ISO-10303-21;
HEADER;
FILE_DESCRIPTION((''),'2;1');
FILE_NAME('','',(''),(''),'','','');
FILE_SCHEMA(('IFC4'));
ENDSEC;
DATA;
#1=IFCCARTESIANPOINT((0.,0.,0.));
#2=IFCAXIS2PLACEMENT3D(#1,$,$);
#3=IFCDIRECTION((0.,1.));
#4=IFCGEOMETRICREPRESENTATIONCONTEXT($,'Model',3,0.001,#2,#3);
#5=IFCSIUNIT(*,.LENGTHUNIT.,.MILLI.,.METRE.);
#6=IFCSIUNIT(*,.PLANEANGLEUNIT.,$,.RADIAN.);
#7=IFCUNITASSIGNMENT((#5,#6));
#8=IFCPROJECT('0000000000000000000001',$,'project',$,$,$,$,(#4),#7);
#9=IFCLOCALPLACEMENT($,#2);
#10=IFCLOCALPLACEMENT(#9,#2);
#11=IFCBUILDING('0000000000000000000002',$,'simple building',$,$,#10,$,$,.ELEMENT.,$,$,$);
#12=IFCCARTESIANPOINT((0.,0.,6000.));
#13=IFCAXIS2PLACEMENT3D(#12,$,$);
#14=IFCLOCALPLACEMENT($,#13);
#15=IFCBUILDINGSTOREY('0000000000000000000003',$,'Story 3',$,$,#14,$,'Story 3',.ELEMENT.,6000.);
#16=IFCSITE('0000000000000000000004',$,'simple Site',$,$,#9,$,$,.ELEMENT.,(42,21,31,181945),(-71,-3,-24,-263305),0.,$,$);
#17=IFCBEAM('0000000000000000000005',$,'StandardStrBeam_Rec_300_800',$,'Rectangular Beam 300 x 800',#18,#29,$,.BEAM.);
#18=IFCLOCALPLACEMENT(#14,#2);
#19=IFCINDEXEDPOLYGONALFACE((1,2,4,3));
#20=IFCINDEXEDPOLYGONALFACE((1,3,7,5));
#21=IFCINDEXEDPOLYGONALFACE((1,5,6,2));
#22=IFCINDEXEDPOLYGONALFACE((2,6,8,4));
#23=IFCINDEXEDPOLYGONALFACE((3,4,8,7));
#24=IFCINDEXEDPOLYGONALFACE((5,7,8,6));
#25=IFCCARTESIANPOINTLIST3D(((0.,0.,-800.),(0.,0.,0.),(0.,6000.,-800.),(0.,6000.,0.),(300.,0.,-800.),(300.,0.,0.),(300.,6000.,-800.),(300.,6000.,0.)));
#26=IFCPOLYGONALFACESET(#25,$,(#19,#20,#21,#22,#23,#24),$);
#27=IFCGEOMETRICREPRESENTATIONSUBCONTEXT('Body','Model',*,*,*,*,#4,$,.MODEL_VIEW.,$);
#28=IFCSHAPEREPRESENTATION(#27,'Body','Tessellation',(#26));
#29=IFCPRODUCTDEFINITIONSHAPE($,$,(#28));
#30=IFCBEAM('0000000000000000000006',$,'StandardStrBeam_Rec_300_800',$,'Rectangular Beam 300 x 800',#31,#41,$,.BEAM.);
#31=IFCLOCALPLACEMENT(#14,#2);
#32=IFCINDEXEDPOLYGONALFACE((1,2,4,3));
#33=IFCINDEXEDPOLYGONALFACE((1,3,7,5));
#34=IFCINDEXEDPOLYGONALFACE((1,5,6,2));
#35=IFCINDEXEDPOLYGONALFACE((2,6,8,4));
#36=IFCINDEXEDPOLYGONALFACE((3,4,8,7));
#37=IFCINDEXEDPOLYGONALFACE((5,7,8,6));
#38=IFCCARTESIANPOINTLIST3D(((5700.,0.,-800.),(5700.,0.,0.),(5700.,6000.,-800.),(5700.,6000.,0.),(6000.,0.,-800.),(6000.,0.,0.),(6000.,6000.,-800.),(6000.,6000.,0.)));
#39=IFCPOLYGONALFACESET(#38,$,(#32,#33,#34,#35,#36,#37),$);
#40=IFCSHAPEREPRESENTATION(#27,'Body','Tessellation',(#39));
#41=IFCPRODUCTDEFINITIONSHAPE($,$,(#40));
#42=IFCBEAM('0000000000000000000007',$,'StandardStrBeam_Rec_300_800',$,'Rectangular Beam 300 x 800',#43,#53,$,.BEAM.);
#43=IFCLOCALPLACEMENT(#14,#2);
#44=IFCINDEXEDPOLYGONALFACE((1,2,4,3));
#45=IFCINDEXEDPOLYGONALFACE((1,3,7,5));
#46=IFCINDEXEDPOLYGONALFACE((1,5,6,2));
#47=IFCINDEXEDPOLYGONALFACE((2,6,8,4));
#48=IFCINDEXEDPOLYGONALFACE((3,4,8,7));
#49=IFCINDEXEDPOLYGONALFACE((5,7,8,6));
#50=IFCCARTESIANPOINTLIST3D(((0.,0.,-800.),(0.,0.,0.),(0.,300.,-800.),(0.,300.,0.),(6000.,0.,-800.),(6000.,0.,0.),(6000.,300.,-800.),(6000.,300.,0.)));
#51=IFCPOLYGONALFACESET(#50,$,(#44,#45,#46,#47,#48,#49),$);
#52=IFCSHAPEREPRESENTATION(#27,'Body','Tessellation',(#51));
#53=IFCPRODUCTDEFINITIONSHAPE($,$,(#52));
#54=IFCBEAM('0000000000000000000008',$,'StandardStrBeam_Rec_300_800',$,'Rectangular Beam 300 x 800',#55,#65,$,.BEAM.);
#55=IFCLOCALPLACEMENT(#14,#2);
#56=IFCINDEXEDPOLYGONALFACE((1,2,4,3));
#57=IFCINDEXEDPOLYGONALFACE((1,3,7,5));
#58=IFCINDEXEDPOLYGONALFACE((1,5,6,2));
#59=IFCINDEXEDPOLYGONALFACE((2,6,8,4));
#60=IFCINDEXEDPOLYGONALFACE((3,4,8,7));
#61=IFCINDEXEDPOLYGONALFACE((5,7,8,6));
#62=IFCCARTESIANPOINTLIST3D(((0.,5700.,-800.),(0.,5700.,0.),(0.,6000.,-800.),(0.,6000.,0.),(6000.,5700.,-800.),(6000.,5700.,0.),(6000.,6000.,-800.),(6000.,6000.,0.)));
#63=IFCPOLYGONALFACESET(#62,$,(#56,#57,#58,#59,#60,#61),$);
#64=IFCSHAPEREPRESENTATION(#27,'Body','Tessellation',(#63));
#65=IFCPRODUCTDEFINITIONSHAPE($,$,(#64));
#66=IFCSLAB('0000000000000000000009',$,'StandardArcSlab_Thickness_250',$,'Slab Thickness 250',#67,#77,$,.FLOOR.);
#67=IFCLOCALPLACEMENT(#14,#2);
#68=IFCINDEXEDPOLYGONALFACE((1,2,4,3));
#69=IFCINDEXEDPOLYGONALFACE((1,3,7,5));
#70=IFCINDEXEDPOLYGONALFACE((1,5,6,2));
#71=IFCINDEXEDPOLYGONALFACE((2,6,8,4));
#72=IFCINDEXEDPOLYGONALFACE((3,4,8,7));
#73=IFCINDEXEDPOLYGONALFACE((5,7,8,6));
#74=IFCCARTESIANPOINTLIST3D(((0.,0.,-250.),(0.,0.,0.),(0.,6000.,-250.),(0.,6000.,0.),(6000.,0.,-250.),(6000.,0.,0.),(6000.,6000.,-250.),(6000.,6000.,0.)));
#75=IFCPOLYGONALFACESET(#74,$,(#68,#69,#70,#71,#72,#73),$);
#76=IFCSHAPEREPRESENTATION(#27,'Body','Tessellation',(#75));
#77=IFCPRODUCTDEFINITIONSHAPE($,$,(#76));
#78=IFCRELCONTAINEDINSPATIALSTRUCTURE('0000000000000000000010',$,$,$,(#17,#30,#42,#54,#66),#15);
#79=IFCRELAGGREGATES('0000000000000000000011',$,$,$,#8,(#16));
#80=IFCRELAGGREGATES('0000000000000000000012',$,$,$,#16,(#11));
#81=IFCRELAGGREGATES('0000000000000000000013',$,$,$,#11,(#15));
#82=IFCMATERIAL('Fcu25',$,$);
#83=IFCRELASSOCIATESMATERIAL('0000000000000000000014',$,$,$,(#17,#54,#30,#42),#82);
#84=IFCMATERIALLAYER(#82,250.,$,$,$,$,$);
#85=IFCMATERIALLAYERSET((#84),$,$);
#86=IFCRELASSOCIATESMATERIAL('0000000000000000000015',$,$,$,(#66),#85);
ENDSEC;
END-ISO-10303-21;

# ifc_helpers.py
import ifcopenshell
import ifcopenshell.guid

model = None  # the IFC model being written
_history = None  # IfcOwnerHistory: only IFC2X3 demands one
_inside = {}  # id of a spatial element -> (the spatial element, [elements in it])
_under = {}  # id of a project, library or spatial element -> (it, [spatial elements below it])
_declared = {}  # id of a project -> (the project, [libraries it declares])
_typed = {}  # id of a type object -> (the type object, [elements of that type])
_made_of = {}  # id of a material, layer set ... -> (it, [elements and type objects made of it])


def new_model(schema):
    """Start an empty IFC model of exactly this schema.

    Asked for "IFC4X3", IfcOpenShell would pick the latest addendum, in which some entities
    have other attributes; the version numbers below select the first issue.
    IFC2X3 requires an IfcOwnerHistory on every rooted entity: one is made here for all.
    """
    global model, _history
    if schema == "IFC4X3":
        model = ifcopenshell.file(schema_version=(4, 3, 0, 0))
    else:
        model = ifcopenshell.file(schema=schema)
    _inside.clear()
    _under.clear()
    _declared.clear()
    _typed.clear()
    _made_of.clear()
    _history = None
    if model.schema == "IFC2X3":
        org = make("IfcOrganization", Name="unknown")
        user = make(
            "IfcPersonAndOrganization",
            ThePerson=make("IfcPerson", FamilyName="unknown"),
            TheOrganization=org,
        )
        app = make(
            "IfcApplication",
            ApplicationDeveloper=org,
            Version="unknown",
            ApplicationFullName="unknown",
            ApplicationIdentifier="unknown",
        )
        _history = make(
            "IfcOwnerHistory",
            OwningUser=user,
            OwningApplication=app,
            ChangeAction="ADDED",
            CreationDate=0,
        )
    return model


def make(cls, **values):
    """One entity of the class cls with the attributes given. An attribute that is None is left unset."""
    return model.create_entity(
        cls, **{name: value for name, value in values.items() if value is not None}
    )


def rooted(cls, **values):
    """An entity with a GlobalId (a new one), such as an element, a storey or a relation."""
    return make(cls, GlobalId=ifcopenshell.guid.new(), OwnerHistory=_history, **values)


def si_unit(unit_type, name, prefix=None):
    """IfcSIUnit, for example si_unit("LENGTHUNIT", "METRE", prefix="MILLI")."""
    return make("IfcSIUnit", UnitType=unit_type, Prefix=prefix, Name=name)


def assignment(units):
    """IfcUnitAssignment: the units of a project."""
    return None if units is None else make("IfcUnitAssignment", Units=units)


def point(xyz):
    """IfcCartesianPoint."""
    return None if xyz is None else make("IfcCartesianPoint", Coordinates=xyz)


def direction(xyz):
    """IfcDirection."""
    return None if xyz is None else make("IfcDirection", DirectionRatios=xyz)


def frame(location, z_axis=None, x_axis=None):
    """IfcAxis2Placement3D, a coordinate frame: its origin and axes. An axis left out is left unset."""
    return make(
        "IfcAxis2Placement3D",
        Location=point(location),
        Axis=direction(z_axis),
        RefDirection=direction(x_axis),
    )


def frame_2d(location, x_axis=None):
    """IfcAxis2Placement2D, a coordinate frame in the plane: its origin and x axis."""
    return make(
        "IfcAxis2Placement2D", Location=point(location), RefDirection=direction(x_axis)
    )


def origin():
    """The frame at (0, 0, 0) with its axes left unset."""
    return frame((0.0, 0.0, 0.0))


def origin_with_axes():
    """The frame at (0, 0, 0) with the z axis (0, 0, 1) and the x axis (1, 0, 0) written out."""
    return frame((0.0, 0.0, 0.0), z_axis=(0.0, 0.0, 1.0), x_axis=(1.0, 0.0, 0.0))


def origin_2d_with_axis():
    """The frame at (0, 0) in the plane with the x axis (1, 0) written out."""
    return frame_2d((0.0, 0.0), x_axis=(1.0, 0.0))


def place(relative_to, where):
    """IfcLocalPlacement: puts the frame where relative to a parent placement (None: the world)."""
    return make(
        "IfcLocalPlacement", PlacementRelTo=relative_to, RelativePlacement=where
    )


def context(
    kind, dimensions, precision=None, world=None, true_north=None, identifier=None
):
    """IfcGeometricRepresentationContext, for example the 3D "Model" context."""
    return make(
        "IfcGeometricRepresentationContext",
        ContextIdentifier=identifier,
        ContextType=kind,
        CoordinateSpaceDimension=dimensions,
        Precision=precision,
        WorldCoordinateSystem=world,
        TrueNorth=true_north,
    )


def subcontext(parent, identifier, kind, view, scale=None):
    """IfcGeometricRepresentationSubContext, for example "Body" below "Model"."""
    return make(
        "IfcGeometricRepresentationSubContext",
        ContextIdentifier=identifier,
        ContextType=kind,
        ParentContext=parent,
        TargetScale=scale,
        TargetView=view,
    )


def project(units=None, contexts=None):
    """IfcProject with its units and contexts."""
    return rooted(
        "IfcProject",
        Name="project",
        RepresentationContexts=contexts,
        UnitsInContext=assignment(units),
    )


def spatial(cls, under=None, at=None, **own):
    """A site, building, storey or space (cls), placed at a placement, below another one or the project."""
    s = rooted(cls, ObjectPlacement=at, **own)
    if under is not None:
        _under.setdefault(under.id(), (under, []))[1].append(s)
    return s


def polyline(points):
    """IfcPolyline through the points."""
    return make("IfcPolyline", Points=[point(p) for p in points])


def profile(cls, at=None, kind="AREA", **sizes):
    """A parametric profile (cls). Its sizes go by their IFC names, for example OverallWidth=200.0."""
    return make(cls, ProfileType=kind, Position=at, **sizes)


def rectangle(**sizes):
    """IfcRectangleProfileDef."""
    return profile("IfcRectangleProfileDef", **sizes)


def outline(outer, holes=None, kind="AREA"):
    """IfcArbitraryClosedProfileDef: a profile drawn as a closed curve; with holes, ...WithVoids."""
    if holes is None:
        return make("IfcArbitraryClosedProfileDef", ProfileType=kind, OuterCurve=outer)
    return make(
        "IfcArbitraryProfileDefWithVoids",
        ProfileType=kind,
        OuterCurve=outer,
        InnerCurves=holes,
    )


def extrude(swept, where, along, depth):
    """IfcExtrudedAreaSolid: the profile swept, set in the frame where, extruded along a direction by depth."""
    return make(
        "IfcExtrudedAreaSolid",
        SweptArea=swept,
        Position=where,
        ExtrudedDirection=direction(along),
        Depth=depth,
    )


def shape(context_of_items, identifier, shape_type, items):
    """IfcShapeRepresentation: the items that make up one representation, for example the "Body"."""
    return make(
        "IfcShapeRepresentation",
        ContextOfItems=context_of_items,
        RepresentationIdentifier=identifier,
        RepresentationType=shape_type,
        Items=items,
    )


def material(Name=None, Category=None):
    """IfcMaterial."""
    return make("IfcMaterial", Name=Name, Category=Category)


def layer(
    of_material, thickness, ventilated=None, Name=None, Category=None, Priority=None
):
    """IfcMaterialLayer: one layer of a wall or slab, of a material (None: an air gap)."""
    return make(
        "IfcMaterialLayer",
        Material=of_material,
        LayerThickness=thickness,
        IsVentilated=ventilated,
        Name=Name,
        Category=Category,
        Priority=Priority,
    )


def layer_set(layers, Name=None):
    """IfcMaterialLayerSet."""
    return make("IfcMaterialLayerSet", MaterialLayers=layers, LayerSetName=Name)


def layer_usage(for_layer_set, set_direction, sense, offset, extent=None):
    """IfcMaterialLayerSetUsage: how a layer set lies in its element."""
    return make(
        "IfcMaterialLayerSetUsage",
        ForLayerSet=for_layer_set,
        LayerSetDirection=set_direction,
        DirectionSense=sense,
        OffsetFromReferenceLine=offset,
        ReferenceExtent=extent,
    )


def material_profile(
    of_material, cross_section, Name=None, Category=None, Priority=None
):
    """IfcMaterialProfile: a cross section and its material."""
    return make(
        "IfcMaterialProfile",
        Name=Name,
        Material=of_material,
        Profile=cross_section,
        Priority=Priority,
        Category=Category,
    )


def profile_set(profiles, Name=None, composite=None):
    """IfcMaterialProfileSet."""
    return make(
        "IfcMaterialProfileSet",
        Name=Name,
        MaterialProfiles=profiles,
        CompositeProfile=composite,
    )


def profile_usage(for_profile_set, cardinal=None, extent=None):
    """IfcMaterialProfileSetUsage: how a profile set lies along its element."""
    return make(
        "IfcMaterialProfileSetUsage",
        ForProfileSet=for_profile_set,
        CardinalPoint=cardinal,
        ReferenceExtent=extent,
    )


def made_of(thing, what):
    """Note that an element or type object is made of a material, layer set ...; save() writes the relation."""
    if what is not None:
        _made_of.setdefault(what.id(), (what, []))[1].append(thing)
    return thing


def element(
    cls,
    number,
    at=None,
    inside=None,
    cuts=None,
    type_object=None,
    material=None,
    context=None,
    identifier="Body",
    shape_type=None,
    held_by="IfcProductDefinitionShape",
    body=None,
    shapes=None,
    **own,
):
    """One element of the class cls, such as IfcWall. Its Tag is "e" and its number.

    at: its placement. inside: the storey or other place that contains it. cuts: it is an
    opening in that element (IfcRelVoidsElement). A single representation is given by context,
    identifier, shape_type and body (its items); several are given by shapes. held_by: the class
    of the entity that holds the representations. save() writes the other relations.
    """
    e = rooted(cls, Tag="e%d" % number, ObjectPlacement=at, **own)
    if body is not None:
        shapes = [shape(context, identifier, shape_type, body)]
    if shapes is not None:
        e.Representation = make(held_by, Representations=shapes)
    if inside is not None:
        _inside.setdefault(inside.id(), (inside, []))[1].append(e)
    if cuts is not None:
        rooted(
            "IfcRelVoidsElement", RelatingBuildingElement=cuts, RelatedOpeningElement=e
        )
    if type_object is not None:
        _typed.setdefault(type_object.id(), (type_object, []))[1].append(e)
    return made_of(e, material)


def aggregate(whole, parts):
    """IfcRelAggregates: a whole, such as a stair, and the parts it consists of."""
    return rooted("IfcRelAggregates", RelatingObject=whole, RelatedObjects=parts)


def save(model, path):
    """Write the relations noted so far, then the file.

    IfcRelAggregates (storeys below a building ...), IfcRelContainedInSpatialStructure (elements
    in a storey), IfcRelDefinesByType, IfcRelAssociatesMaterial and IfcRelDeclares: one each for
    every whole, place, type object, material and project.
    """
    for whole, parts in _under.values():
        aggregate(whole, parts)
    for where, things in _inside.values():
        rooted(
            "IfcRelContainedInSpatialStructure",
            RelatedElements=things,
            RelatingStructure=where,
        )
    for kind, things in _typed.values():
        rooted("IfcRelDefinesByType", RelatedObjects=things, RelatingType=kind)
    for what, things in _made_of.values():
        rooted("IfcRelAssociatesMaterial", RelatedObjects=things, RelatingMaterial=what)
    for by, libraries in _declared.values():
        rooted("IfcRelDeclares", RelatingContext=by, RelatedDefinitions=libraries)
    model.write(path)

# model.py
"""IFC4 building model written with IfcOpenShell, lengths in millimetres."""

from ifc_helpers import new_model, si_unit, direction, frame, origin, origin_with_axes, origin_2d_with_axis, place, context, subcontext, project, spatial, polyline, rectangle, outline, extrude, material, layer, layer_set, layer_usage, material_profile, profile_set, profile_usage, element, save


model = new_model("IFC4")

# Units and contexts
model_context = context("Model", 3, precision=0.001, world=origin(), true_north=direction((0.0, 1.0)))
body_context = subcontext(model_context, "Body", "Model", "MODEL_VIEW")
ifc_project = project(units=[si_unit("LENGTHUNIT", "METRE", prefix="MILLI"), si_unit("PLANEANGLEUNIT", "RADIAN")], contexts=[model_context])

# Site, building, storey
site_placement = place(None, origin())
site = spatial("IfcSite", under=ifc_project, at=site_placement, Name="simple Site", CompositionType="ELEMENT", RefLatitude=(42, 21, 31, 181945), RefLongitude=(-71, -3, -24, -263305), RefElevation=0.0)
building_placement = place(site_placement, origin())
building = spatial("IfcBuilding", under=site, at=building_placement, Name="simple building", CompositionType="ELEMENT")
storey_placement = place(None, frame((0.0, 0.0, 6000.0)))
storey = spatial("IfcBuildingStorey", under=building, at=storey_placement, Name="Story 3", LongName="Story 3", CompositionType="ELEMENT", Elevation=6000.0)

# Beams
ifc_material = material(Name="Fcu25")
ifc_material_profile = material_profile(ifc_material, rectangle(XDim=300.0, YDim=800.0, at=origin_2d_with_axis()))
ifc_profile_set = profile_set([ifc_material_profile])
ifc_profile_usage_1 = profile_usage(ifc_profile_set, cardinal=7)
beam_1_placement = place(None, frame((150.0, 0.0, 5600.0), z_axis=(0.0, 1.0, 0.0), x_axis=(1.0, 0.0, 0.0)))
element("IfcBeam", 1, at=beam_1_placement, inside=storey, material=ifc_profile_usage_1, Name="StandardStrBeam_Rec_300_800", ObjectType="Rectangular Beam 300 x 800", PredefinedType="BEAM", context=body_context, shape_type="SweptSolid", body=[
    extrude(rectangle(XDim=300.0, YDim=800.0, at=origin_2d_with_axis()), origin_with_axes(), (0.0, 0.0, 1.0), 6000.0),
])
ifc_profile_usage_2 = profile_usage(ifc_profile_set, cardinal=9)
for number, where, z_axis, x_axis, name in (
    (2, (5850.0, 0.0, 5600.0), (0.0, 1.0, 0.0), (1.0, 0.0, 0.0), "StandardStrBeam_Rec_300_800"),
    (3, (0.0, 150.0, 5600.0), (1.0, 0.0, 0.0), (0.0, -1.0, 0.0), "StandardStrBeam_Rec_300_800"),
):
    element("IfcBeam", number, at=place(None, frame(where, z_axis=z_axis, x_axis=x_axis)), inside=storey, material=ifc_profile_usage_2, Name=name, ObjectType="Rectangular Beam 300 x 800", PredefinedType="BEAM", context=body_context, shape_type="SweptSolid", body=[
        extrude(rectangle(XDim=300.0, YDim=800.0, at=origin_2d_with_axis()), origin_with_axes(), (0.0, 0.0, 1.0), 6000.0),
    ])
beam_2_placement = place(None, frame((0.0, 5850.0, 5600.0), z_axis=(1.0, 0.0, 0.0), x_axis=(0.0, -1.0, 0.0)))
element("IfcBeam", 4, at=beam_2_placement, inside=storey, material=ifc_profile_usage_1, Name="StandardStrBeam_Rec_300_800", ObjectType="Rectangular Beam 300 x 800", PredefinedType="BEAM", context=body_context, shape_type="SweptSolid", body=[
    extrude(rectangle(XDim=300.0, YDim=800.0, at=origin_2d_with_axis()), origin_with_axes(), (0.0, 0.0, 1.0), 6000.0),
])

# Slab
ifc_layer = layer(ifc_material, 250.0)
ifc_layer_set = layer_set([ifc_layer])
ifc_layer_usage = layer_usage(ifc_layer_set, "AXIS3", "POSITIVE", -250.0)
slab_placement = place(None, frame((0.0, 0.0, 5750.0), z_axis=(0.0, 0.0, 1.0), x_axis=(1.0, 0.0, 0.0)))
element("IfcSlab", 5, at=slab_placement, inside=storey, material=ifc_layer_usage, Name="StandardArcSlab_Thickness_250", ObjectType="Slab Thickness 250", PredefinedType="FLOOR", context=body_context, shape_type="SweptSolid", body=[
    extrude(outline(polyline([(0.0, 0.0), (6000.0, 0.0), (6000.0, 6000.0), (0.0, 6000.0), (0.0, 0.0)])), origin_with_axes(), (0.0, 0.0, 1.0), 250.0),
])

save(model, "model.ifc")
